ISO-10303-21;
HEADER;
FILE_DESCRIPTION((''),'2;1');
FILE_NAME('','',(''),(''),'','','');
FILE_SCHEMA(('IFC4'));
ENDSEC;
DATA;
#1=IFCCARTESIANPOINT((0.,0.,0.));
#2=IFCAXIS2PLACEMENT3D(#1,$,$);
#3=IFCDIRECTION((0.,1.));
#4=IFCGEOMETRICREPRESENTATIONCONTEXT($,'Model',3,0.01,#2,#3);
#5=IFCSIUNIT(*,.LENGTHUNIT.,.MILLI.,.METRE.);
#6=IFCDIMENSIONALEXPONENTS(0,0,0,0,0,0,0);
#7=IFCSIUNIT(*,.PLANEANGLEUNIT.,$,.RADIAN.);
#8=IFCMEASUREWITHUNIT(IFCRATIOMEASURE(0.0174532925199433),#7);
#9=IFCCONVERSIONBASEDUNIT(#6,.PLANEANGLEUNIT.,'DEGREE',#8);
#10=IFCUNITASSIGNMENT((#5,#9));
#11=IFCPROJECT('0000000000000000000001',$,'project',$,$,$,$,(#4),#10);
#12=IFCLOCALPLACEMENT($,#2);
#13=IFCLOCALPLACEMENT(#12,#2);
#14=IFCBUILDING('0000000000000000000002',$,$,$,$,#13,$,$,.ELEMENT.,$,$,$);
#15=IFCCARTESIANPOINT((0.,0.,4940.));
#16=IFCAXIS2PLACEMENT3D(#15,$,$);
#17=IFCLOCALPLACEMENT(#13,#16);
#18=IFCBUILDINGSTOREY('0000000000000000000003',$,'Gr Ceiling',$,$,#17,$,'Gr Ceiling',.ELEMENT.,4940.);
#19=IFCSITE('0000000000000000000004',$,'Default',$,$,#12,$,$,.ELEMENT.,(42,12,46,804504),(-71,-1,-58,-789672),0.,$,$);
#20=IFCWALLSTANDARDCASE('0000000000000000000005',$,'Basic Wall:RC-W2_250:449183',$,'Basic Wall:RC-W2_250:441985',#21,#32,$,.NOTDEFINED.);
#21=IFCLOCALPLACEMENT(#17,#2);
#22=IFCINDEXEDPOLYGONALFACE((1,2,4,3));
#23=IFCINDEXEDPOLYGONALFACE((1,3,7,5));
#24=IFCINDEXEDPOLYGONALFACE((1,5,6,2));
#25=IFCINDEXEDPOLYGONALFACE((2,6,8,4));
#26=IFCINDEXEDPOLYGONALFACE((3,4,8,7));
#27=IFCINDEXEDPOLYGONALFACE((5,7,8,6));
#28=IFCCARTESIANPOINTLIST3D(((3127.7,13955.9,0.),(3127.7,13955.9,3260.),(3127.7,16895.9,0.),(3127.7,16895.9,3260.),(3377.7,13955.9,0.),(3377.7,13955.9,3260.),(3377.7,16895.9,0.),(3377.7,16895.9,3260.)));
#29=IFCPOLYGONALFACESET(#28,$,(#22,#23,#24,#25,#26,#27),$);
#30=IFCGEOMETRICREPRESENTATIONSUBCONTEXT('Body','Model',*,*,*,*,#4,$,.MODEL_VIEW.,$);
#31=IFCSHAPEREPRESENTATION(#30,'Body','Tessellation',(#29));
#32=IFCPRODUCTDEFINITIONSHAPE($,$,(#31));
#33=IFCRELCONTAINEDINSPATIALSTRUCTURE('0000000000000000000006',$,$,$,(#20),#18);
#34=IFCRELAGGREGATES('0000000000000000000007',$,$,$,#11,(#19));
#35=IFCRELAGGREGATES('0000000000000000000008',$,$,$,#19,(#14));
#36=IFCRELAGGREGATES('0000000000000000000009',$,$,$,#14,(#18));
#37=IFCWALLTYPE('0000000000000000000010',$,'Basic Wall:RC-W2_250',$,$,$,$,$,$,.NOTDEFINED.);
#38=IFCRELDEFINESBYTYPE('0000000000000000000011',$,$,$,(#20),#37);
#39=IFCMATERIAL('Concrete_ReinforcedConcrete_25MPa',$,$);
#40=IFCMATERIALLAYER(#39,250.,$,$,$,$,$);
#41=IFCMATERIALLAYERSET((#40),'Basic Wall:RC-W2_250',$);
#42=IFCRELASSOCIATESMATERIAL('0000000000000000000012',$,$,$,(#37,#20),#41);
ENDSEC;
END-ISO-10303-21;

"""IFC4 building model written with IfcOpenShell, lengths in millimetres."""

from ifc_helpers import new_model, entity, si_unit, converted_unit, direction, frame, frame_2d, origin, place, context, subcontext, project, spatial, polyline, rectangle, extrude, clip, bounded_halfspace, material, layer, layer_set, layer_usage, type_object, element, save


model = new_model("IFC4")

# Units and contexts
model_context = context("Model", 3, precision=0.01, world=origin(), true_north=direction((0.0, 1.0)))
body_context = subcontext(model_context, "Body", "Model", "MODEL_VIEW")
ifc_project = project(units=[si_unit("LENGTHUNIT", "METRE", prefix="MILLI"), converted_unit("PLANEANGLEUNIT", "DEGREE", entity("IfcRatioMeasure", 0.0174532925199433), si_unit("PLANEANGLEUNIT", "RADIAN"), dimensions=[0, 0, 0, 0, 0, 0, 0])], contexts=[model_context])

# Site, building, storey
site_placement = place(None, origin())
site = spatial("IfcSite", under=ifc_project, at=site_placement, Name="Default", CompositionType="ELEMENT", RefLatitude=(42, 12, 46, 804504), RefLongitude=(-71, -1, -58, -789672), RefElevation=0.0)
building_placement = place(site_placement, origin())
building = spatial("IfcBuilding", under=site, at=building_placement, CompositionType="ELEMENT")
storey_placement = place(building_placement, frame((0.0, 0.0, 4940.0)))
storey = spatial("IfcBuildingStorey", under=building, at=storey_placement, Name="Gr Ceiling", LongName="Gr Ceiling", CompositionType="ELEMENT", Elevation=4940.0)

# Shared definitions
ifc_material = material(Name="Concrete_ReinforcedConcrete_25MPa")

# Wall
ifc_layer_1 = layer(ifc_material, 250.0)
ifc_layer_set_1 = layer_set([ifc_layer_1], Name="Basic Wall:RC-W2_250")
ifc_layer_usage_1 = layer_usage(ifc_layer_set_1, "AXIS2", "NEGATIVE", 125.0)
wall_type_1 = type_object("IfcWallType", Name="Basic Wall:RC-W2_250", PredefinedType="NOTDEFINED", material=ifc_layer_set_1)
wall_1_placement = place(storey_placement, frame((3252.7, 13955.9, 0.0), z_axis=(0.0, 0.0, 1.0), x_axis=(0.0, 1.0, 0.0)))
element("IfcWallStandardCase", 1, at=wall_1_placement, inside=storey, type_object=wall_type_1, material=ifc_layer_usage_1, Name="Basic Wall:RC-W2_250:449183", ObjectType="Basic Wall:RC-W2_250:441985", PredefinedType="NOTDEFINED", context=body_context, shape_type="Clipping", body=[
    clip(extrude(rectangle(XDim=2940.0, YDim=250.0, at=frame_2d((1470.0, 0.0), x_axis=(-1.0, 0.0))), origin(), (0.0, 0.0, 1.0), 3260.0), bounded_halfspace(frame((0.0, -125.0, 3260.0), z_axis=(0.0, 0.0, -1.0), x_axis=(0.0, -1.0, 0.0)), True, frame((0.0, -125.0, 3260.0)), polyline([(0.0, 0.0), (2940.0, 0.0), (2940.0, 250.0), (0.0, 250.0), (0.0, 0.0)]))),
])

save(model, "model.ifc")
